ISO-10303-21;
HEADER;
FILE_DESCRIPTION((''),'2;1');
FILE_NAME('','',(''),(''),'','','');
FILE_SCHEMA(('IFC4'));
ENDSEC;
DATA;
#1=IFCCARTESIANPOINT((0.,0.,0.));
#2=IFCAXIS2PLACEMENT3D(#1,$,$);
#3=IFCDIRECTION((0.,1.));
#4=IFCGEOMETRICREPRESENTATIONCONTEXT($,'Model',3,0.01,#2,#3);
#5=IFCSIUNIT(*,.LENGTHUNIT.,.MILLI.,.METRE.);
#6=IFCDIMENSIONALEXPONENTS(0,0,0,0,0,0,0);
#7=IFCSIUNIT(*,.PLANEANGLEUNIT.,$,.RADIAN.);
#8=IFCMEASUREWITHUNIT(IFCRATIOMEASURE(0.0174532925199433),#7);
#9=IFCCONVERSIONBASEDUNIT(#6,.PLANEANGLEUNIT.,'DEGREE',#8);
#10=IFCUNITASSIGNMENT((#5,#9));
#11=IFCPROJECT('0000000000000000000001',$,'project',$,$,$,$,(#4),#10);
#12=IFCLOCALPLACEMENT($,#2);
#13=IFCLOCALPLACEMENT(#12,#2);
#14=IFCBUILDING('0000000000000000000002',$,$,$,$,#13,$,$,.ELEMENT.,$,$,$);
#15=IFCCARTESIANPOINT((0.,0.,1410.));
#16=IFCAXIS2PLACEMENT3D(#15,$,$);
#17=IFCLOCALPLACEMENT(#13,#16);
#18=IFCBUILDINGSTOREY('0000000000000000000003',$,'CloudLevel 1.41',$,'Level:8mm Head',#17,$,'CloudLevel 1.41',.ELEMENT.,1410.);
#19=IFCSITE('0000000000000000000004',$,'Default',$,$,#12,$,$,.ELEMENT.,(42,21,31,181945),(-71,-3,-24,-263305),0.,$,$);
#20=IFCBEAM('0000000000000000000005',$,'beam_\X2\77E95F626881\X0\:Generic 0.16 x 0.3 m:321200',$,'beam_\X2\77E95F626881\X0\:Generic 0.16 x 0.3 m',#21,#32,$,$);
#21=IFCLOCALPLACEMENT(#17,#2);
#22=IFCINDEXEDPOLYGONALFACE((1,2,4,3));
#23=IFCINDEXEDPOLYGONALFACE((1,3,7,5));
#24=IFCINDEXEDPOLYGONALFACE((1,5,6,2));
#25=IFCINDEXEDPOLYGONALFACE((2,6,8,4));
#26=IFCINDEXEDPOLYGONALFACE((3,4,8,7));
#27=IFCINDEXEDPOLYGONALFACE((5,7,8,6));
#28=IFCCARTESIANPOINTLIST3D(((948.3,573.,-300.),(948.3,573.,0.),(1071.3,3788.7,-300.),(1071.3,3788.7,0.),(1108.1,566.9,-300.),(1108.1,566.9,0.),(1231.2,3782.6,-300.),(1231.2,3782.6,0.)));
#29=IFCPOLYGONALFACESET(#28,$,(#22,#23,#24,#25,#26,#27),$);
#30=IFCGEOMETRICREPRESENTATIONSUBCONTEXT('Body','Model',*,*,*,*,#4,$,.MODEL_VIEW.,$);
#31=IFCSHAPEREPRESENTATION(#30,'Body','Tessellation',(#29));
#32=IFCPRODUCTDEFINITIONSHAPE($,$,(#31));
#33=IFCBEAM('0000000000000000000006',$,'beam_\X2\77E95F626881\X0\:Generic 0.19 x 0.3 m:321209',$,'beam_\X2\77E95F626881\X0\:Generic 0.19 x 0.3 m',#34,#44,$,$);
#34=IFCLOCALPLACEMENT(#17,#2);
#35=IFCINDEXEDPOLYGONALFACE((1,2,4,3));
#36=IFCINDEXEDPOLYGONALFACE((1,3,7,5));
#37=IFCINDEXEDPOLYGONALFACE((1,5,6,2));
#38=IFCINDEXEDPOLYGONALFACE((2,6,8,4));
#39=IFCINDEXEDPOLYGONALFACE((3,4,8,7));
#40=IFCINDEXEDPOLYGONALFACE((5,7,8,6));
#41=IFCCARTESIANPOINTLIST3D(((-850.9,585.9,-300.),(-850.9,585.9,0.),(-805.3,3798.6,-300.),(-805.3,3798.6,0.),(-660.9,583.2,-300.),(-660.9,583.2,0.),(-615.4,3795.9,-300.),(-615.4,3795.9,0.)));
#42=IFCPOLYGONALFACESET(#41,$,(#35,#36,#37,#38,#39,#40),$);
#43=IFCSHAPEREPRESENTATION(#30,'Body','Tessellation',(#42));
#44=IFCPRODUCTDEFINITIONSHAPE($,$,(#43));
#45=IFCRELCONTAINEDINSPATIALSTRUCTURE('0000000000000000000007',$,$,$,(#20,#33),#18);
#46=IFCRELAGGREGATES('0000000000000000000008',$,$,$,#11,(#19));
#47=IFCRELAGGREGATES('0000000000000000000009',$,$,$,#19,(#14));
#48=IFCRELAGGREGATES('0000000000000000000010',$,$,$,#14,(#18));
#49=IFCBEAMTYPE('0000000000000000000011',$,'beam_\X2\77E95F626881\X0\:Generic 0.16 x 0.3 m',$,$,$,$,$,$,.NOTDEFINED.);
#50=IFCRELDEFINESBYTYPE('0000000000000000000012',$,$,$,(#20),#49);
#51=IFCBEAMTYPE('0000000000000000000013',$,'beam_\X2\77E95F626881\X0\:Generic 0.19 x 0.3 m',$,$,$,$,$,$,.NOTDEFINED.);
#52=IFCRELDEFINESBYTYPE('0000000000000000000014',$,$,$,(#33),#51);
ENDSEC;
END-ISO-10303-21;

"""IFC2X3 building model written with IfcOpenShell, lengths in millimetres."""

from ifc_helpers import new_model, entity, si_unit, converted_unit, direction, frame, frame_2d, origin, place, context, subcontext, project, spatial, rectangle, extrude, type_object, element, save


model = new_model("IFC2X3")

# Units and contexts
model_context = context("Model", 3, precision=0.01, world=origin(), true_north=direction((0.0, 1.0)))
body_context = subcontext(model_context, "Body", "Model", "MODEL_VIEW")
ifc_project = project(units=[si_unit("LENGTHUNIT", "METRE", prefix="MILLI"), converted_unit("PLANEANGLEUNIT", "DEGREE", entity("IfcRatioMeasure", 0.0174532925199433), si_unit("PLANEANGLEUNIT", "RADIAN"), dimensions=[0, 0, 0, 0, 0, 0, 0])], contexts=[model_context])

# Site, building, storey
site_placement = place(None, origin())
site = spatial("IfcSite", under=ifc_project, at=site_placement, Name="Default", CompositionType="ELEMENT", RefLatitude=(42, 21, 31, 181945), RefLongitude=(-71, -3, -24, -263305), RefElevation=0.0)
building_placement = place(site_placement, origin())
building = spatial("IfcBuilding", under=site, at=building_placement, CompositionType="ELEMENT")
storey_placement = place(building_placement, frame((0.0, 0.0, 1410.0)))
storey = spatial("IfcBuildingStorey", under=building, at=storey_placement, Name="CloudLevel 1.41", ObjectType="Level:8mm Head", LongName="CloudLevel 1.41", CompositionType="ELEMENT", Elevation=1410.0)

# Beams
beam_type_1 = type_object("IfcBeamType", Name="beam_矩形梁:Generic 0.16 x 0.3 m", PredefinedType="NOTDEFINED")
beam_1_placement = place(storey_placement, frame((1028.2, 569.7, 0.0), z_axis=(0.0, 0.0, 1.0), x_axis=(0.038243, 0.999268, 0.0)))
element("IfcBeam", 1, at=beam_1_placement, inside=storey, type_object=beam_type_1, Name="beam_矩形梁:Generic 0.16 x 0.3 m:321200", ObjectType="beam_矩形梁:Generic 0.16 x 0.3 m", context=body_context, shape_type="SweptSolid", body=[
    extrude(rectangle(XDim=300.0, YDim=160.0, at=frame_2d((0.0, 0.0), x_axis=(1.0, 0.0))), frame((0.3, 0.0, -150.0), z_axis=(1.0, 0.0, 0.0), x_axis=(0.0, 0.0, -1.0)), (0.0, 0.0, 1.0), 3218.0),
])
beam_type_2 = type_object("IfcBeamType", Name="beam_矩形梁:Generic 0.19 x 0.3 m", PredefinedType="NOTDEFINED")
beam_2_placement = place(storey_placement, frame((-710.4, 3797.4, 0.0), z_axis=(0.0, 0.0, 1.0), x_axis=(-0.014183, -0.999899, 0.0)))
element("IfcBeam", 2, at=beam_2_placement, inside=storey, type_object=beam_type_2, Name="beam_矩形梁:Generic 0.19 x 0.3 m:321209", ObjectType="beam_矩形梁:Generic 0.19 x 0.3 m", context=body_context, shape_type="SweptSolid", body=[
    extrude(rectangle(XDim=300.0, YDim=190.0, at=frame_2d((0.0, 0.0), x_axis=(1.0, 0.0))), frame((0.2, 0.0, -150.0), z_axis=(1.0, 0.0, 0.0), x_axis=(0.0, 0.0, -1.0)), (0.0, 0.0, 1.0), 3213.0),
])

save(model, "model.ifc")
